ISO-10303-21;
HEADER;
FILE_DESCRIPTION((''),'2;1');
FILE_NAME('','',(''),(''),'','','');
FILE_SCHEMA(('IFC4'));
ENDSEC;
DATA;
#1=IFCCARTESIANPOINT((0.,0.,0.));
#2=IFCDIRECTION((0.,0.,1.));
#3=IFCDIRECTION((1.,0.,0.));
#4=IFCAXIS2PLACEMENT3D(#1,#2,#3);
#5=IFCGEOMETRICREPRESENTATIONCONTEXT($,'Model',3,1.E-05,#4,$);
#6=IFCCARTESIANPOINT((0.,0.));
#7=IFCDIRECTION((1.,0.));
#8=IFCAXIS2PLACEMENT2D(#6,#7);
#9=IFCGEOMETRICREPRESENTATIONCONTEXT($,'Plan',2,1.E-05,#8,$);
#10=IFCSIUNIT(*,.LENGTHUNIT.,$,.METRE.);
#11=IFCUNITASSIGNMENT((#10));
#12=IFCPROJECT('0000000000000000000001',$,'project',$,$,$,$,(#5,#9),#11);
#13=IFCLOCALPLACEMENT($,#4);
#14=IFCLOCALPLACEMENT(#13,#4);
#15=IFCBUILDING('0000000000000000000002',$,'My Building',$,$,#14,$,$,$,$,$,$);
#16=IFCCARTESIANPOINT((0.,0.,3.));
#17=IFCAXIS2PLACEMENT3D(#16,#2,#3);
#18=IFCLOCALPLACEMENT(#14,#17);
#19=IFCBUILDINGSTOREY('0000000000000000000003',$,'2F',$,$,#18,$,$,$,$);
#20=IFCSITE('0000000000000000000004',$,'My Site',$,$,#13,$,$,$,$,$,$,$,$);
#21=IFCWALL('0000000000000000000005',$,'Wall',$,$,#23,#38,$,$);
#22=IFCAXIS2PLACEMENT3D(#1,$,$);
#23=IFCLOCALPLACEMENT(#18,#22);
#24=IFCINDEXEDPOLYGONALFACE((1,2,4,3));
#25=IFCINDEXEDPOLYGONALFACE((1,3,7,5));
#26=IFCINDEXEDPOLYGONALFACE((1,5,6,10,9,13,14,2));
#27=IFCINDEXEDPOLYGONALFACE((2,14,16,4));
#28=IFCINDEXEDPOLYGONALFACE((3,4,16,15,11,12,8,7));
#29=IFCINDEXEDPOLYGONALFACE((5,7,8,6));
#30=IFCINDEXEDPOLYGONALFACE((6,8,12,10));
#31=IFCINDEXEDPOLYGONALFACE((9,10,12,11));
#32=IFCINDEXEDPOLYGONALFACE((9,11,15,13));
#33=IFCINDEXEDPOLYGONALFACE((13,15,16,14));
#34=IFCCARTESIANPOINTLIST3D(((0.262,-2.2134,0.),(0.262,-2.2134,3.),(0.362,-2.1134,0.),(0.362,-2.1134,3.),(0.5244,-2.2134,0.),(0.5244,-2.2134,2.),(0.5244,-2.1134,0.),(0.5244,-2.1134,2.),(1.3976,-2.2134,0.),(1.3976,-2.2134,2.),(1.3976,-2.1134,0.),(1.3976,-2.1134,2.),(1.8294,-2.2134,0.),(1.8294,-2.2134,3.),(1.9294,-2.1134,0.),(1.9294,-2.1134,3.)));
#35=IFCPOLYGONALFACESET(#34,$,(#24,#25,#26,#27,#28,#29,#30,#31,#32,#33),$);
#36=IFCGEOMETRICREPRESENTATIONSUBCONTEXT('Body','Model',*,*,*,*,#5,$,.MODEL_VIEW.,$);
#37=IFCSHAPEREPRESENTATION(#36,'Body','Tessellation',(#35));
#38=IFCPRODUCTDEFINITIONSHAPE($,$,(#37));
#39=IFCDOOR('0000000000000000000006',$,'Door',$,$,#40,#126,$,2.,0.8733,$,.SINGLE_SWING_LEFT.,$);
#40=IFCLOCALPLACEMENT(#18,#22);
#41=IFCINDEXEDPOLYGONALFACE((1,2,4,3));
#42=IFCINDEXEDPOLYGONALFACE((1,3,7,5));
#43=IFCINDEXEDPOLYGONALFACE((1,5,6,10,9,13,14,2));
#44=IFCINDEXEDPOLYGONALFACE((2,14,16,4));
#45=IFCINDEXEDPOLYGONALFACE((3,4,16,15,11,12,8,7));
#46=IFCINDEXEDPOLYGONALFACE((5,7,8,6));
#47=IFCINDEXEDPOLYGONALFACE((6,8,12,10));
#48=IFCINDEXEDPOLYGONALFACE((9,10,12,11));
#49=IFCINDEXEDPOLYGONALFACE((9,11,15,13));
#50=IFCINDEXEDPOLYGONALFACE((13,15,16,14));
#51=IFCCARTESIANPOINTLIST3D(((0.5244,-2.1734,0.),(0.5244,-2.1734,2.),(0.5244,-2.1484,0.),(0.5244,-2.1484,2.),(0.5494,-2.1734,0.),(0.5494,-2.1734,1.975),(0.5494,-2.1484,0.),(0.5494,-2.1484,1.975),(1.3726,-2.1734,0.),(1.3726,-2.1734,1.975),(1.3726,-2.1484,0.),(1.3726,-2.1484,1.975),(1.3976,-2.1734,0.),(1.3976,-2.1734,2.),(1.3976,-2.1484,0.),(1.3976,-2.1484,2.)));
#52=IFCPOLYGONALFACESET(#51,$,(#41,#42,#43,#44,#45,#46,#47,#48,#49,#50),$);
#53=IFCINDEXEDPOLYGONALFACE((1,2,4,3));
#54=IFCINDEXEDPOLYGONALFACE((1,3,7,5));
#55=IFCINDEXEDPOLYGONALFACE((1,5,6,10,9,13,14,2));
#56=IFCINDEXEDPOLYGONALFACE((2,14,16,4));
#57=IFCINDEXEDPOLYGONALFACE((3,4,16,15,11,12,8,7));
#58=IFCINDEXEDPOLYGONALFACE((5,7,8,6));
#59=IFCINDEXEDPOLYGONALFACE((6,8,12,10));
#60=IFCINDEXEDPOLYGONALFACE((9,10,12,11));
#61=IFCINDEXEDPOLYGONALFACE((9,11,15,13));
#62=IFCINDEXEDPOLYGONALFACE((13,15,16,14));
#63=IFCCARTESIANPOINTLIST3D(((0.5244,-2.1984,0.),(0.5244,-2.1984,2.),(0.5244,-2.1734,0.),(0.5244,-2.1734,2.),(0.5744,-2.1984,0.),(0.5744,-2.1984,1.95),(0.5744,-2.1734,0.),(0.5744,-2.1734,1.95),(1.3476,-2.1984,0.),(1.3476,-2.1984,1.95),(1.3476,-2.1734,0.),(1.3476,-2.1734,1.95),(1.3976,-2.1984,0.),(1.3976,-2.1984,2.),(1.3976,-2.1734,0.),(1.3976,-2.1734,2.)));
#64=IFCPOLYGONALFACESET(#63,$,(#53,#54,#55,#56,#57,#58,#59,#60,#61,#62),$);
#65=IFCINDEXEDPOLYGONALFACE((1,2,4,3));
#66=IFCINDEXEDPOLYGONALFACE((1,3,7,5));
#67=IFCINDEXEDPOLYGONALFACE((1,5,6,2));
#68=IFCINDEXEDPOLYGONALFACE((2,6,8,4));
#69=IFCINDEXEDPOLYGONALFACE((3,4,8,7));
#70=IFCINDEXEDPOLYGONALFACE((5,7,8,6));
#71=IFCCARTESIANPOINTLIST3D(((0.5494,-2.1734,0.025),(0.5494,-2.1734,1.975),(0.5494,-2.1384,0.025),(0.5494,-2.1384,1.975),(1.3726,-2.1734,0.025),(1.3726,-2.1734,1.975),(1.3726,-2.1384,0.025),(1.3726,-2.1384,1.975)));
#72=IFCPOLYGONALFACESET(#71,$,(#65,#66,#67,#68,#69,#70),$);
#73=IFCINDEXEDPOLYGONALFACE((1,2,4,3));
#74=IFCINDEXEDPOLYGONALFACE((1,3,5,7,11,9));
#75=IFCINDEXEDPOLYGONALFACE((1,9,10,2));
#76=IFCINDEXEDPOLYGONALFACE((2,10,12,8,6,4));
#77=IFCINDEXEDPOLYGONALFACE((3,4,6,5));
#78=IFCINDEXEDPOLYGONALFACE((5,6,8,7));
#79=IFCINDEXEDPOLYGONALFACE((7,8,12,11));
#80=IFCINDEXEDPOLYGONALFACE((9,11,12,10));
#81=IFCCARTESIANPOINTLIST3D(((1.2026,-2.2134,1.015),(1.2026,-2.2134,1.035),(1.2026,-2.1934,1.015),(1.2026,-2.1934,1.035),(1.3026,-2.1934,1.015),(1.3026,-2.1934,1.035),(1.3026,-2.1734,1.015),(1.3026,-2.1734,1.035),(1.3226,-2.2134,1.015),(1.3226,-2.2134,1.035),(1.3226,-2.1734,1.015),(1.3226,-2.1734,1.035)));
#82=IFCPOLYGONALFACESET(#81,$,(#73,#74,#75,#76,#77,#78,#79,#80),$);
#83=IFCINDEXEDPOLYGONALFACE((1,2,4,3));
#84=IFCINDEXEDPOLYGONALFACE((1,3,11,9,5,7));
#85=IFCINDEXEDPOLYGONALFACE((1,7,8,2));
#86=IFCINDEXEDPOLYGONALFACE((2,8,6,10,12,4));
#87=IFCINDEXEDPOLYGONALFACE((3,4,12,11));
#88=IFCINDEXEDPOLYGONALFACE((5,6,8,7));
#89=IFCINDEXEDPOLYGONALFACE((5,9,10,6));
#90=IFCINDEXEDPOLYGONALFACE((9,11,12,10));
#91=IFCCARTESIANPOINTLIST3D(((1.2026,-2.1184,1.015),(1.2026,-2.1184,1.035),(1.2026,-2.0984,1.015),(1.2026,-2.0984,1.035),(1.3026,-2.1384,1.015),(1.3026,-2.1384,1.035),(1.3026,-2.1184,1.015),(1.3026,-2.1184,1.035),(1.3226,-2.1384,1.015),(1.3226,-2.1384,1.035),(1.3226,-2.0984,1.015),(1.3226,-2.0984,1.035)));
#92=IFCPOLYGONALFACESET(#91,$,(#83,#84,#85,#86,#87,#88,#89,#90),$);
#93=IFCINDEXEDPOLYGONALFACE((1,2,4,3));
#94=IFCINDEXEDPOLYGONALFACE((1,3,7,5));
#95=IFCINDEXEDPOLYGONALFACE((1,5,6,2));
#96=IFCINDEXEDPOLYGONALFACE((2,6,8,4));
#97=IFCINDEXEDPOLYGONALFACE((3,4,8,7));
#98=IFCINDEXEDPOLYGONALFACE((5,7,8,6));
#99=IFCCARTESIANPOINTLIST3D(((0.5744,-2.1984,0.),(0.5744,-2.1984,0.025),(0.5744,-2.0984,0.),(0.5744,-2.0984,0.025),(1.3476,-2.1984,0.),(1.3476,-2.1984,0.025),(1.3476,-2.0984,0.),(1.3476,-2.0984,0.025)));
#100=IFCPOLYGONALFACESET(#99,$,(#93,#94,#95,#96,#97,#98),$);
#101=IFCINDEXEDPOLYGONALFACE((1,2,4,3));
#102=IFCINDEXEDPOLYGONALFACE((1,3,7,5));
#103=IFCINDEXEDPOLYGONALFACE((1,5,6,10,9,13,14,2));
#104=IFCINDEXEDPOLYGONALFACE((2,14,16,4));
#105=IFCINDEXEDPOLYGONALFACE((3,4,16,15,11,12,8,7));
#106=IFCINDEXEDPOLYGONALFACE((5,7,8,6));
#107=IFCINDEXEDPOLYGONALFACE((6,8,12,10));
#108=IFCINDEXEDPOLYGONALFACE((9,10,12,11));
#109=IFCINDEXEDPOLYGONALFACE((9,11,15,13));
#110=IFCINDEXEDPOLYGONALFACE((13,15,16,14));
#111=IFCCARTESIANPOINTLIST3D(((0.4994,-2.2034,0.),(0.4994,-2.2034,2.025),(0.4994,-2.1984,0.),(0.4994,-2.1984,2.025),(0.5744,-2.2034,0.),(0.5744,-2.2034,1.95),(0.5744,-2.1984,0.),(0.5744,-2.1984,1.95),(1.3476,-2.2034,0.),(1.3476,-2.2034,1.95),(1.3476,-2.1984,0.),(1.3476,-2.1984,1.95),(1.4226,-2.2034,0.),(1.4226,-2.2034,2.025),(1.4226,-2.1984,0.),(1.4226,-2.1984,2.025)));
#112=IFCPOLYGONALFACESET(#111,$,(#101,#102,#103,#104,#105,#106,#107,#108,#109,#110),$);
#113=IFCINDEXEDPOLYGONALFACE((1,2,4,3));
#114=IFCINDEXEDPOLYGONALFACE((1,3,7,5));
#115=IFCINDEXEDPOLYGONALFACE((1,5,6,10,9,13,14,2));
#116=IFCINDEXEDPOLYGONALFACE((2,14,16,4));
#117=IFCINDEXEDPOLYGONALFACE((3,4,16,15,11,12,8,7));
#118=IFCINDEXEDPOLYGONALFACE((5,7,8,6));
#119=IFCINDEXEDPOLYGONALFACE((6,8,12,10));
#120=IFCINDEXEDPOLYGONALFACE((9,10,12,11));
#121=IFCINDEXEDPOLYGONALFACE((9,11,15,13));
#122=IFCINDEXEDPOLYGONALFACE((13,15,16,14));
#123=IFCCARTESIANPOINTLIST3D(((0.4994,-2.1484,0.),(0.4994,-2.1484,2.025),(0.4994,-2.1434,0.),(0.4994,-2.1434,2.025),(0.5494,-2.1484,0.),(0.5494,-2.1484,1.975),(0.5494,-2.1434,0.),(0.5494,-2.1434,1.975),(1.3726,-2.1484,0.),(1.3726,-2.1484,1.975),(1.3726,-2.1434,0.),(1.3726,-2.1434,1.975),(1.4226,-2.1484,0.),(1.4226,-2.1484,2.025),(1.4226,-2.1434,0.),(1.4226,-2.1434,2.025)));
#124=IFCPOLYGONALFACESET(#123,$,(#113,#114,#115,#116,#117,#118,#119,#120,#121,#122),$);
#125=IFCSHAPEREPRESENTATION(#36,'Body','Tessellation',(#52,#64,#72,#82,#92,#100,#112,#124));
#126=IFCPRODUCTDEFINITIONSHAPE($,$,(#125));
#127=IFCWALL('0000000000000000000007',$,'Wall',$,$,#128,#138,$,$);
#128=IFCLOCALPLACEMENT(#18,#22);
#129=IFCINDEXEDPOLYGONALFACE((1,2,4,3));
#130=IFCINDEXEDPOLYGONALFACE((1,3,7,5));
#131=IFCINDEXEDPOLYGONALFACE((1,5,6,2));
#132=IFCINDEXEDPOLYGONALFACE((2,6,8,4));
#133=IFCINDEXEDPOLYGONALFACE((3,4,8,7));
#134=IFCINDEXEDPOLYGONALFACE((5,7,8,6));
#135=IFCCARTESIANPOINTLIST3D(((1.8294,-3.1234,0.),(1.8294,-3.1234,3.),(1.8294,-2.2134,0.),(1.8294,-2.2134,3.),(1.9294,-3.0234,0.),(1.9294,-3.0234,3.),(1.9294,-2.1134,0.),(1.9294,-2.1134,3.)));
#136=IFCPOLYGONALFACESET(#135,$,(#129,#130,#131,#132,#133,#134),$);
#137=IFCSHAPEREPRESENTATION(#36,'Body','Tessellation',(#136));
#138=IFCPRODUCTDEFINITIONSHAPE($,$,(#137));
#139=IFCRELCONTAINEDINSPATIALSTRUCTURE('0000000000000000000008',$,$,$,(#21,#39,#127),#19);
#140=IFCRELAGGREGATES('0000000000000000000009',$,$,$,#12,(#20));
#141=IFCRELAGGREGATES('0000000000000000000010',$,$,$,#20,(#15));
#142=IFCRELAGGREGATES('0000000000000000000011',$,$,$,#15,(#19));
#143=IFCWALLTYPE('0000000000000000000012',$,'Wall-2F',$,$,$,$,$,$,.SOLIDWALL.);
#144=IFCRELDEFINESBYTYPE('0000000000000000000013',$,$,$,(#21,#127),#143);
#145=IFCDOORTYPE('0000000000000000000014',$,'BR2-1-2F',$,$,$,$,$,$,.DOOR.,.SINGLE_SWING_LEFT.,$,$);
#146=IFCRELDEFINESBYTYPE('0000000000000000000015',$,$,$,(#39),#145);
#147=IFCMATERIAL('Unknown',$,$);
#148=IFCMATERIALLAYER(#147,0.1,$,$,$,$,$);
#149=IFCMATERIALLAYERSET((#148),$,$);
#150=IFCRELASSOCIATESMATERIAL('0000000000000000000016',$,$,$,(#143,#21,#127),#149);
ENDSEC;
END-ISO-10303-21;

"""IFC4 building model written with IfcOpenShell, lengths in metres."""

from ifc_helpers import new_model, entity, si_unit, frame, origin_with_axes, origin_2d_with_axis, place, context, subcontext, project, spatial, line, indexed_curve, outline, extrude, shape, source, transform, mapped, material, layer, layer_set, layer_usage, type_object, type_shapes, element, fill, save


model = new_model("IFC4")

# Units and contexts
model_context = context("Model", 3, precision=1e-05, world=origin_with_axes())
plan_context = context("Plan", 2, precision=1e-05, world=origin_2d_with_axis())
body_context_1 = subcontext(model_context, "Body", "Model", "MODEL_VIEW")
body_context_2 = subcontext(plan_context, "Body", "Plan", "PLAN_VIEW")
ifc_project = project(units=[si_unit("LENGTHUNIT", "METRE")], contexts=[model_context, plan_context])

# Site, building, storey
site_placement = place(None, origin_with_axes())
site = spatial("IfcSite", under=ifc_project, at=site_placement, Name="My Site")
building_placement = place(site_placement, origin_with_axes())
building = spatial("IfcBuilding", under=site, at=building_placement, Name="My Building")
storey_placement = place(building_placement, frame((0.0, 0.0, 3.0), z_axis=(0.0, 0.0, 1.0), x_axis=(1.0, 0.0, 0.0)))
storey = spatial("IfcBuildingStorey", under=building, at=storey_placement, Name="2F")

# Shared definitions
ifc_material = material(Name="Unknown")

# Shared definitions
ifc_layer = layer(ifc_material, 0.1)
ifc_layer_set = layer_set([ifc_layer])
wall_type = type_object("IfcWallType", Name="Wall-2F", PredefinedType="SOLIDWALL", material=ifc_layer_set)

# Wall, opening, door
ifc_layer_usage_1 = layer_usage(ifc_layer_set, "AXIS2", "POSITIVE", 0.0)
wall_1_placement = place(storey_placement, frame((0.262, -2.2134, 0.0), z_axis=(0.0, 0.0, 1.0), x_axis=(1.0, 0.0, 0.0)))
wall_1 = element("IfcWall", 1, at=wall_1_placement, inside=storey, type_object=wall_type, material=ifc_layer_usage_1, Name="Wall", context=body_context_1, shape_type="SweptSolid", body=[
    extrude(outline(indexed_curve([(0.0, 0.0), (0.1, 0.1), (1.6674, 0.1), (1.5674, 0.0)], segments=[line(1, 2, 3, 4, 1)])), origin_with_axes(), (0.0, 0.0, 1.0), 3.0),
])
shared_shape_1 = source(origin_with_axes(), body_context_1, "Body", "SweptSolid", [
    extrude(outline(indexed_curve([(0.0, 0.0), (0.8733, 0.0), (0.8733, 2.0), (0.0, 2.0)], segments=[line(1, 2, 3, 4, 1)])), frame((0.0, -0.6, 0.0), z_axis=(0.0, -1.0, 0.0), x_axis=(1.0, 0.0, 0.0)), (0.0, 0.0, -1.0), 1.2),
])
opening_1_placement = place(wall_1_placement, frame((0.2623, 0.015, 0.0), z_axis=(0.0, 0.0, 1.0), x_axis=(1.0, 0.0, 0.0)))
opening_1 = element("IfcOpeningElement", 2, at=opening_1_placement, cuts=wall_1, PredefinedType="OPENING", context=body_context_1, shape_type="MappedRepresentation", body=[
    mapped(shared_shape_1, transform((0.0, 0.0, 0.0), x_axis=(1.0, 0.0, 0.0), y_axis=(0.0, 1.0, 0.0), z_axis=(0.0, 0.0, 1.0), scale=1.0)),
])
door_type_1 = type_object("IfcDoorType", Name="BR2-1-2F", OperationType="SINGLE_SWING_LEFT", PredefinedType="DOOR")
shared_shape_2 = source(origin_with_axes(), body_context_1, "Body", "SweptSolid", [
    extrude(outline(indexed_curve([(0.0, 0.0), (0.0, 2.0), (0.8733, 2.0), (0.8733, 0.0), (0.8483, 0.0), (0.8483, 1.975), (0.025, 1.975), (0.025, 0.0)], segments=[line(1, 2, 3, 4, 5, 6, 7, 8, 1)])), frame((0.0, 0.025, 0.0), z_axis=(0.0, -1.0, 0.0), x_axis=(1.0, 0.0, 0.0)), (0.0, 0.0, -1.0), 0.025),
    extrude(outline(indexed_curve([(0.0, 0.0), (0.0, 2.0), (0.8733, 2.0), (0.8733, 0.0), (0.8233, 0.0), (0.8233, 1.95), (0.05, 1.95), (0.05, 0.0)], segments=[line(1, 2, 3, 4, 5, 6, 7, 8, 1)])), frame((0.0, 0.0, 0.0), z_axis=(0.0, -1.0, 0.0), x_axis=(1.0, 0.0, 0.0)), (0.0, 0.0, -1.0), 0.025),
    extrude(outline(indexed_curve([(0.0, 0.0), (0.8233, 0.0), (0.8233, 0.035), (0.0, 0.035)], segments=[line(1, 2, 3, 4, 1)])), frame((0.025, 0.025, 0.025), z_axis=(0.0, 0.0, 1.0), x_axis=(1.0, 0.0, 0.0)), (0.0, 0.0, 1.0), 1.95),
    extrude(outline(indexed_curve([(0.0, 0.0), (0.0, -0.04), (-0.12, -0.04), (-0.12, -0.02), (-0.02, -0.02), (-0.02, 0.0)], segments=[line(1, 2, 3, 4, 5, 6, 1)])), frame((0.7983, 0.025, 1.015), z_axis=(0.0, 0.0, 1.0), x_axis=(1.0, 0.0, 0.0)), (0.0, 0.0, 1.0), 0.02),
    extrude(outline(indexed_curve([(0.0, 0.0), (0.0, 0.04), (-0.12, 0.04), (-0.12, 0.02), (-0.02, 0.02), (-0.02, 0.0)], segments=[line(1, 2, 3, 4, 5, 6, 1)])), frame((0.7983, 0.06, 1.015), z_axis=(0.0, 0.0, 1.0), x_axis=(1.0, 0.0, 0.0)), (0.0, 0.0, 1.0), 0.02),
    extrude(outline(indexed_curve([(0.0, 0.0), (0.7733, 0.0), (0.7733, 0.1), (0.0, 0.1)], segments=[line(1, 2, 3, 4, 1)])), frame((0.05, 0.0, 0.0), z_axis=(0.0, 0.0, 1.0), x_axis=(1.0, 0.0, 0.0)), (0.0, 0.0, 1.0), 0.025),
    extrude(outline(indexed_curve([(0.0, 0.0), (0.0, 2.025), (0.9233, 2.025), (0.9233, 0.0), (0.8483, 0.0), (0.8483, 1.95), (0.075, 1.95), (0.075, 0.0)], segments=[line(1, 2, 3, 4, 5, 6, 7, 8, 1)])), frame((-0.025, -0.005, 0.0), z_axis=(0.0, -1.0, 0.0), x_axis=(1.0, 0.0, 0.0)), (0.0, 0.0, -1.0), 0.005),
    extrude(outline(indexed_curve([(0.0, 0.0), (0.0, 2.025), (0.9233, 2.025), (0.9233, 0.0), (0.8733, 0.0), (0.8733, 1.975), (0.05, 1.975), (0.05, 0.0)], segments=[line(1, 2, 3, 4, 5, 6, 7, 8, 1)])), frame((-0.025, 0.05, 0.0), z_axis=(0.0, -1.0, 0.0), x_axis=(1.0, 0.0, 0.0)), (0.0, 0.0, -1.0), 0.005),
])
shared_shape_3 = source(origin_with_axes(), body_context_2, "Body", "Curve2D", [
    entity("IfcIndexedPolyCurve", entity("IfcCartesianPointList2D", [[0.0, 0.0], [0.0, 0.05], [0.025, 0.05], [0.025, 0.025], [0.05, 0.025], [0.05, 0.0]]), [entity("IfcLineIndex", [1, 2, 3, 4, 5, 6, 1])]),
    entity("IfcIndexedPolyCurve", entity("IfcCartesianPointList2D", [[0.8733, 0.0], [0.8733, 0.05], [0.8483, 0.05], [0.8483, 0.025], [0.8233, 0.025], [0.8233, 0.0]]), [entity("IfcLineIndex", [1, 2, 3, 4, 5, 6, 1])]),
    entity("IfcTrimmedCurve", entity("IfcEllipse", entity("IfcAxis2Placement2D", entity("IfcCartesianPoint", [0.06, 0.05]), entity("IfcDirection", [1.0, 0.0])), 0.7883, 0.8233), [entity("IfcCartesianPoint", [0.8483, 0.05])], [entity("IfcCartesianPoint", [0.06, 0.8733])], True, "CARTESIAN"),
    entity("IfcIndexedPolyCurve", entity("IfcCartesianPointList2D", [[0.025, 0.05], [0.06, 0.05], [0.06, 0.8733], [0.025, 0.8733]]), [entity("IfcLineIndex", [1, 2, 3, 4, 1])]),
])
type_shapes(door_type_1, [shared_shape_2, shared_shape_3])
door_1_placement = place(opening_1_placement, origin_with_axes())
door_1 = element("IfcDoor", 3, at=door_1_placement, inside=storey, type_object=door_type_1, Name="Door", OperationType="SINGLE_SWING_LEFT", OverallHeight=2.0, OverallWidth=0.8733, shapes=[
    shape(body_context_1, "Body", "MappedRepresentation", [mapped(shared_shape_2, transform((0.0, 0.0, 0.0), x_axis=(1.0, 0.0, 0.0), y_axis=(0.0, 1.0, 0.0), z_axis=(0.0, 0.0, 1.0), scale=1.0))]),
    shape(body_context_2, "Body", "MappedRepresentation", [mapped(shared_shape_3, transform((0.0, 0.0, 0.0), x_axis=(1.0, 0.0, 0.0), y_axis=(0.0, 1.0, 0.0), z_axis=(0.0, 0.0, 1.0), scale=1.0))]),
])
fill(opening_1, door_1)

# Wall
ifc_layer_usage_2 = layer_usage(ifc_layer_set, "AXIS2", "POSITIVE", 0.0)
wall_2_placement = place(storey_placement, frame((1.8294, -2.2134, 0.0), z_axis=(0.0, 0.0, 1.0), x_axis=(0.0, -1.0, 0.0)))
element("IfcWall", 4, at=wall_2_placement, inside=storey, type_object=wall_type, material=ifc_layer_usage_2, Name="Wall", context=body_context_1, shape_type="SweptSolid", body=[
    extrude(outline(indexed_curve([(0.0, 0.0), (-0.1, 0.1), (0.81, 0.1), (0.91, 0.0)], segments=[line(1, 2, 3, 4, 1)])), origin_with_axes(), (0.0, 0.0, 1.0), 3.0),
])

save(model, "model.ifc")
